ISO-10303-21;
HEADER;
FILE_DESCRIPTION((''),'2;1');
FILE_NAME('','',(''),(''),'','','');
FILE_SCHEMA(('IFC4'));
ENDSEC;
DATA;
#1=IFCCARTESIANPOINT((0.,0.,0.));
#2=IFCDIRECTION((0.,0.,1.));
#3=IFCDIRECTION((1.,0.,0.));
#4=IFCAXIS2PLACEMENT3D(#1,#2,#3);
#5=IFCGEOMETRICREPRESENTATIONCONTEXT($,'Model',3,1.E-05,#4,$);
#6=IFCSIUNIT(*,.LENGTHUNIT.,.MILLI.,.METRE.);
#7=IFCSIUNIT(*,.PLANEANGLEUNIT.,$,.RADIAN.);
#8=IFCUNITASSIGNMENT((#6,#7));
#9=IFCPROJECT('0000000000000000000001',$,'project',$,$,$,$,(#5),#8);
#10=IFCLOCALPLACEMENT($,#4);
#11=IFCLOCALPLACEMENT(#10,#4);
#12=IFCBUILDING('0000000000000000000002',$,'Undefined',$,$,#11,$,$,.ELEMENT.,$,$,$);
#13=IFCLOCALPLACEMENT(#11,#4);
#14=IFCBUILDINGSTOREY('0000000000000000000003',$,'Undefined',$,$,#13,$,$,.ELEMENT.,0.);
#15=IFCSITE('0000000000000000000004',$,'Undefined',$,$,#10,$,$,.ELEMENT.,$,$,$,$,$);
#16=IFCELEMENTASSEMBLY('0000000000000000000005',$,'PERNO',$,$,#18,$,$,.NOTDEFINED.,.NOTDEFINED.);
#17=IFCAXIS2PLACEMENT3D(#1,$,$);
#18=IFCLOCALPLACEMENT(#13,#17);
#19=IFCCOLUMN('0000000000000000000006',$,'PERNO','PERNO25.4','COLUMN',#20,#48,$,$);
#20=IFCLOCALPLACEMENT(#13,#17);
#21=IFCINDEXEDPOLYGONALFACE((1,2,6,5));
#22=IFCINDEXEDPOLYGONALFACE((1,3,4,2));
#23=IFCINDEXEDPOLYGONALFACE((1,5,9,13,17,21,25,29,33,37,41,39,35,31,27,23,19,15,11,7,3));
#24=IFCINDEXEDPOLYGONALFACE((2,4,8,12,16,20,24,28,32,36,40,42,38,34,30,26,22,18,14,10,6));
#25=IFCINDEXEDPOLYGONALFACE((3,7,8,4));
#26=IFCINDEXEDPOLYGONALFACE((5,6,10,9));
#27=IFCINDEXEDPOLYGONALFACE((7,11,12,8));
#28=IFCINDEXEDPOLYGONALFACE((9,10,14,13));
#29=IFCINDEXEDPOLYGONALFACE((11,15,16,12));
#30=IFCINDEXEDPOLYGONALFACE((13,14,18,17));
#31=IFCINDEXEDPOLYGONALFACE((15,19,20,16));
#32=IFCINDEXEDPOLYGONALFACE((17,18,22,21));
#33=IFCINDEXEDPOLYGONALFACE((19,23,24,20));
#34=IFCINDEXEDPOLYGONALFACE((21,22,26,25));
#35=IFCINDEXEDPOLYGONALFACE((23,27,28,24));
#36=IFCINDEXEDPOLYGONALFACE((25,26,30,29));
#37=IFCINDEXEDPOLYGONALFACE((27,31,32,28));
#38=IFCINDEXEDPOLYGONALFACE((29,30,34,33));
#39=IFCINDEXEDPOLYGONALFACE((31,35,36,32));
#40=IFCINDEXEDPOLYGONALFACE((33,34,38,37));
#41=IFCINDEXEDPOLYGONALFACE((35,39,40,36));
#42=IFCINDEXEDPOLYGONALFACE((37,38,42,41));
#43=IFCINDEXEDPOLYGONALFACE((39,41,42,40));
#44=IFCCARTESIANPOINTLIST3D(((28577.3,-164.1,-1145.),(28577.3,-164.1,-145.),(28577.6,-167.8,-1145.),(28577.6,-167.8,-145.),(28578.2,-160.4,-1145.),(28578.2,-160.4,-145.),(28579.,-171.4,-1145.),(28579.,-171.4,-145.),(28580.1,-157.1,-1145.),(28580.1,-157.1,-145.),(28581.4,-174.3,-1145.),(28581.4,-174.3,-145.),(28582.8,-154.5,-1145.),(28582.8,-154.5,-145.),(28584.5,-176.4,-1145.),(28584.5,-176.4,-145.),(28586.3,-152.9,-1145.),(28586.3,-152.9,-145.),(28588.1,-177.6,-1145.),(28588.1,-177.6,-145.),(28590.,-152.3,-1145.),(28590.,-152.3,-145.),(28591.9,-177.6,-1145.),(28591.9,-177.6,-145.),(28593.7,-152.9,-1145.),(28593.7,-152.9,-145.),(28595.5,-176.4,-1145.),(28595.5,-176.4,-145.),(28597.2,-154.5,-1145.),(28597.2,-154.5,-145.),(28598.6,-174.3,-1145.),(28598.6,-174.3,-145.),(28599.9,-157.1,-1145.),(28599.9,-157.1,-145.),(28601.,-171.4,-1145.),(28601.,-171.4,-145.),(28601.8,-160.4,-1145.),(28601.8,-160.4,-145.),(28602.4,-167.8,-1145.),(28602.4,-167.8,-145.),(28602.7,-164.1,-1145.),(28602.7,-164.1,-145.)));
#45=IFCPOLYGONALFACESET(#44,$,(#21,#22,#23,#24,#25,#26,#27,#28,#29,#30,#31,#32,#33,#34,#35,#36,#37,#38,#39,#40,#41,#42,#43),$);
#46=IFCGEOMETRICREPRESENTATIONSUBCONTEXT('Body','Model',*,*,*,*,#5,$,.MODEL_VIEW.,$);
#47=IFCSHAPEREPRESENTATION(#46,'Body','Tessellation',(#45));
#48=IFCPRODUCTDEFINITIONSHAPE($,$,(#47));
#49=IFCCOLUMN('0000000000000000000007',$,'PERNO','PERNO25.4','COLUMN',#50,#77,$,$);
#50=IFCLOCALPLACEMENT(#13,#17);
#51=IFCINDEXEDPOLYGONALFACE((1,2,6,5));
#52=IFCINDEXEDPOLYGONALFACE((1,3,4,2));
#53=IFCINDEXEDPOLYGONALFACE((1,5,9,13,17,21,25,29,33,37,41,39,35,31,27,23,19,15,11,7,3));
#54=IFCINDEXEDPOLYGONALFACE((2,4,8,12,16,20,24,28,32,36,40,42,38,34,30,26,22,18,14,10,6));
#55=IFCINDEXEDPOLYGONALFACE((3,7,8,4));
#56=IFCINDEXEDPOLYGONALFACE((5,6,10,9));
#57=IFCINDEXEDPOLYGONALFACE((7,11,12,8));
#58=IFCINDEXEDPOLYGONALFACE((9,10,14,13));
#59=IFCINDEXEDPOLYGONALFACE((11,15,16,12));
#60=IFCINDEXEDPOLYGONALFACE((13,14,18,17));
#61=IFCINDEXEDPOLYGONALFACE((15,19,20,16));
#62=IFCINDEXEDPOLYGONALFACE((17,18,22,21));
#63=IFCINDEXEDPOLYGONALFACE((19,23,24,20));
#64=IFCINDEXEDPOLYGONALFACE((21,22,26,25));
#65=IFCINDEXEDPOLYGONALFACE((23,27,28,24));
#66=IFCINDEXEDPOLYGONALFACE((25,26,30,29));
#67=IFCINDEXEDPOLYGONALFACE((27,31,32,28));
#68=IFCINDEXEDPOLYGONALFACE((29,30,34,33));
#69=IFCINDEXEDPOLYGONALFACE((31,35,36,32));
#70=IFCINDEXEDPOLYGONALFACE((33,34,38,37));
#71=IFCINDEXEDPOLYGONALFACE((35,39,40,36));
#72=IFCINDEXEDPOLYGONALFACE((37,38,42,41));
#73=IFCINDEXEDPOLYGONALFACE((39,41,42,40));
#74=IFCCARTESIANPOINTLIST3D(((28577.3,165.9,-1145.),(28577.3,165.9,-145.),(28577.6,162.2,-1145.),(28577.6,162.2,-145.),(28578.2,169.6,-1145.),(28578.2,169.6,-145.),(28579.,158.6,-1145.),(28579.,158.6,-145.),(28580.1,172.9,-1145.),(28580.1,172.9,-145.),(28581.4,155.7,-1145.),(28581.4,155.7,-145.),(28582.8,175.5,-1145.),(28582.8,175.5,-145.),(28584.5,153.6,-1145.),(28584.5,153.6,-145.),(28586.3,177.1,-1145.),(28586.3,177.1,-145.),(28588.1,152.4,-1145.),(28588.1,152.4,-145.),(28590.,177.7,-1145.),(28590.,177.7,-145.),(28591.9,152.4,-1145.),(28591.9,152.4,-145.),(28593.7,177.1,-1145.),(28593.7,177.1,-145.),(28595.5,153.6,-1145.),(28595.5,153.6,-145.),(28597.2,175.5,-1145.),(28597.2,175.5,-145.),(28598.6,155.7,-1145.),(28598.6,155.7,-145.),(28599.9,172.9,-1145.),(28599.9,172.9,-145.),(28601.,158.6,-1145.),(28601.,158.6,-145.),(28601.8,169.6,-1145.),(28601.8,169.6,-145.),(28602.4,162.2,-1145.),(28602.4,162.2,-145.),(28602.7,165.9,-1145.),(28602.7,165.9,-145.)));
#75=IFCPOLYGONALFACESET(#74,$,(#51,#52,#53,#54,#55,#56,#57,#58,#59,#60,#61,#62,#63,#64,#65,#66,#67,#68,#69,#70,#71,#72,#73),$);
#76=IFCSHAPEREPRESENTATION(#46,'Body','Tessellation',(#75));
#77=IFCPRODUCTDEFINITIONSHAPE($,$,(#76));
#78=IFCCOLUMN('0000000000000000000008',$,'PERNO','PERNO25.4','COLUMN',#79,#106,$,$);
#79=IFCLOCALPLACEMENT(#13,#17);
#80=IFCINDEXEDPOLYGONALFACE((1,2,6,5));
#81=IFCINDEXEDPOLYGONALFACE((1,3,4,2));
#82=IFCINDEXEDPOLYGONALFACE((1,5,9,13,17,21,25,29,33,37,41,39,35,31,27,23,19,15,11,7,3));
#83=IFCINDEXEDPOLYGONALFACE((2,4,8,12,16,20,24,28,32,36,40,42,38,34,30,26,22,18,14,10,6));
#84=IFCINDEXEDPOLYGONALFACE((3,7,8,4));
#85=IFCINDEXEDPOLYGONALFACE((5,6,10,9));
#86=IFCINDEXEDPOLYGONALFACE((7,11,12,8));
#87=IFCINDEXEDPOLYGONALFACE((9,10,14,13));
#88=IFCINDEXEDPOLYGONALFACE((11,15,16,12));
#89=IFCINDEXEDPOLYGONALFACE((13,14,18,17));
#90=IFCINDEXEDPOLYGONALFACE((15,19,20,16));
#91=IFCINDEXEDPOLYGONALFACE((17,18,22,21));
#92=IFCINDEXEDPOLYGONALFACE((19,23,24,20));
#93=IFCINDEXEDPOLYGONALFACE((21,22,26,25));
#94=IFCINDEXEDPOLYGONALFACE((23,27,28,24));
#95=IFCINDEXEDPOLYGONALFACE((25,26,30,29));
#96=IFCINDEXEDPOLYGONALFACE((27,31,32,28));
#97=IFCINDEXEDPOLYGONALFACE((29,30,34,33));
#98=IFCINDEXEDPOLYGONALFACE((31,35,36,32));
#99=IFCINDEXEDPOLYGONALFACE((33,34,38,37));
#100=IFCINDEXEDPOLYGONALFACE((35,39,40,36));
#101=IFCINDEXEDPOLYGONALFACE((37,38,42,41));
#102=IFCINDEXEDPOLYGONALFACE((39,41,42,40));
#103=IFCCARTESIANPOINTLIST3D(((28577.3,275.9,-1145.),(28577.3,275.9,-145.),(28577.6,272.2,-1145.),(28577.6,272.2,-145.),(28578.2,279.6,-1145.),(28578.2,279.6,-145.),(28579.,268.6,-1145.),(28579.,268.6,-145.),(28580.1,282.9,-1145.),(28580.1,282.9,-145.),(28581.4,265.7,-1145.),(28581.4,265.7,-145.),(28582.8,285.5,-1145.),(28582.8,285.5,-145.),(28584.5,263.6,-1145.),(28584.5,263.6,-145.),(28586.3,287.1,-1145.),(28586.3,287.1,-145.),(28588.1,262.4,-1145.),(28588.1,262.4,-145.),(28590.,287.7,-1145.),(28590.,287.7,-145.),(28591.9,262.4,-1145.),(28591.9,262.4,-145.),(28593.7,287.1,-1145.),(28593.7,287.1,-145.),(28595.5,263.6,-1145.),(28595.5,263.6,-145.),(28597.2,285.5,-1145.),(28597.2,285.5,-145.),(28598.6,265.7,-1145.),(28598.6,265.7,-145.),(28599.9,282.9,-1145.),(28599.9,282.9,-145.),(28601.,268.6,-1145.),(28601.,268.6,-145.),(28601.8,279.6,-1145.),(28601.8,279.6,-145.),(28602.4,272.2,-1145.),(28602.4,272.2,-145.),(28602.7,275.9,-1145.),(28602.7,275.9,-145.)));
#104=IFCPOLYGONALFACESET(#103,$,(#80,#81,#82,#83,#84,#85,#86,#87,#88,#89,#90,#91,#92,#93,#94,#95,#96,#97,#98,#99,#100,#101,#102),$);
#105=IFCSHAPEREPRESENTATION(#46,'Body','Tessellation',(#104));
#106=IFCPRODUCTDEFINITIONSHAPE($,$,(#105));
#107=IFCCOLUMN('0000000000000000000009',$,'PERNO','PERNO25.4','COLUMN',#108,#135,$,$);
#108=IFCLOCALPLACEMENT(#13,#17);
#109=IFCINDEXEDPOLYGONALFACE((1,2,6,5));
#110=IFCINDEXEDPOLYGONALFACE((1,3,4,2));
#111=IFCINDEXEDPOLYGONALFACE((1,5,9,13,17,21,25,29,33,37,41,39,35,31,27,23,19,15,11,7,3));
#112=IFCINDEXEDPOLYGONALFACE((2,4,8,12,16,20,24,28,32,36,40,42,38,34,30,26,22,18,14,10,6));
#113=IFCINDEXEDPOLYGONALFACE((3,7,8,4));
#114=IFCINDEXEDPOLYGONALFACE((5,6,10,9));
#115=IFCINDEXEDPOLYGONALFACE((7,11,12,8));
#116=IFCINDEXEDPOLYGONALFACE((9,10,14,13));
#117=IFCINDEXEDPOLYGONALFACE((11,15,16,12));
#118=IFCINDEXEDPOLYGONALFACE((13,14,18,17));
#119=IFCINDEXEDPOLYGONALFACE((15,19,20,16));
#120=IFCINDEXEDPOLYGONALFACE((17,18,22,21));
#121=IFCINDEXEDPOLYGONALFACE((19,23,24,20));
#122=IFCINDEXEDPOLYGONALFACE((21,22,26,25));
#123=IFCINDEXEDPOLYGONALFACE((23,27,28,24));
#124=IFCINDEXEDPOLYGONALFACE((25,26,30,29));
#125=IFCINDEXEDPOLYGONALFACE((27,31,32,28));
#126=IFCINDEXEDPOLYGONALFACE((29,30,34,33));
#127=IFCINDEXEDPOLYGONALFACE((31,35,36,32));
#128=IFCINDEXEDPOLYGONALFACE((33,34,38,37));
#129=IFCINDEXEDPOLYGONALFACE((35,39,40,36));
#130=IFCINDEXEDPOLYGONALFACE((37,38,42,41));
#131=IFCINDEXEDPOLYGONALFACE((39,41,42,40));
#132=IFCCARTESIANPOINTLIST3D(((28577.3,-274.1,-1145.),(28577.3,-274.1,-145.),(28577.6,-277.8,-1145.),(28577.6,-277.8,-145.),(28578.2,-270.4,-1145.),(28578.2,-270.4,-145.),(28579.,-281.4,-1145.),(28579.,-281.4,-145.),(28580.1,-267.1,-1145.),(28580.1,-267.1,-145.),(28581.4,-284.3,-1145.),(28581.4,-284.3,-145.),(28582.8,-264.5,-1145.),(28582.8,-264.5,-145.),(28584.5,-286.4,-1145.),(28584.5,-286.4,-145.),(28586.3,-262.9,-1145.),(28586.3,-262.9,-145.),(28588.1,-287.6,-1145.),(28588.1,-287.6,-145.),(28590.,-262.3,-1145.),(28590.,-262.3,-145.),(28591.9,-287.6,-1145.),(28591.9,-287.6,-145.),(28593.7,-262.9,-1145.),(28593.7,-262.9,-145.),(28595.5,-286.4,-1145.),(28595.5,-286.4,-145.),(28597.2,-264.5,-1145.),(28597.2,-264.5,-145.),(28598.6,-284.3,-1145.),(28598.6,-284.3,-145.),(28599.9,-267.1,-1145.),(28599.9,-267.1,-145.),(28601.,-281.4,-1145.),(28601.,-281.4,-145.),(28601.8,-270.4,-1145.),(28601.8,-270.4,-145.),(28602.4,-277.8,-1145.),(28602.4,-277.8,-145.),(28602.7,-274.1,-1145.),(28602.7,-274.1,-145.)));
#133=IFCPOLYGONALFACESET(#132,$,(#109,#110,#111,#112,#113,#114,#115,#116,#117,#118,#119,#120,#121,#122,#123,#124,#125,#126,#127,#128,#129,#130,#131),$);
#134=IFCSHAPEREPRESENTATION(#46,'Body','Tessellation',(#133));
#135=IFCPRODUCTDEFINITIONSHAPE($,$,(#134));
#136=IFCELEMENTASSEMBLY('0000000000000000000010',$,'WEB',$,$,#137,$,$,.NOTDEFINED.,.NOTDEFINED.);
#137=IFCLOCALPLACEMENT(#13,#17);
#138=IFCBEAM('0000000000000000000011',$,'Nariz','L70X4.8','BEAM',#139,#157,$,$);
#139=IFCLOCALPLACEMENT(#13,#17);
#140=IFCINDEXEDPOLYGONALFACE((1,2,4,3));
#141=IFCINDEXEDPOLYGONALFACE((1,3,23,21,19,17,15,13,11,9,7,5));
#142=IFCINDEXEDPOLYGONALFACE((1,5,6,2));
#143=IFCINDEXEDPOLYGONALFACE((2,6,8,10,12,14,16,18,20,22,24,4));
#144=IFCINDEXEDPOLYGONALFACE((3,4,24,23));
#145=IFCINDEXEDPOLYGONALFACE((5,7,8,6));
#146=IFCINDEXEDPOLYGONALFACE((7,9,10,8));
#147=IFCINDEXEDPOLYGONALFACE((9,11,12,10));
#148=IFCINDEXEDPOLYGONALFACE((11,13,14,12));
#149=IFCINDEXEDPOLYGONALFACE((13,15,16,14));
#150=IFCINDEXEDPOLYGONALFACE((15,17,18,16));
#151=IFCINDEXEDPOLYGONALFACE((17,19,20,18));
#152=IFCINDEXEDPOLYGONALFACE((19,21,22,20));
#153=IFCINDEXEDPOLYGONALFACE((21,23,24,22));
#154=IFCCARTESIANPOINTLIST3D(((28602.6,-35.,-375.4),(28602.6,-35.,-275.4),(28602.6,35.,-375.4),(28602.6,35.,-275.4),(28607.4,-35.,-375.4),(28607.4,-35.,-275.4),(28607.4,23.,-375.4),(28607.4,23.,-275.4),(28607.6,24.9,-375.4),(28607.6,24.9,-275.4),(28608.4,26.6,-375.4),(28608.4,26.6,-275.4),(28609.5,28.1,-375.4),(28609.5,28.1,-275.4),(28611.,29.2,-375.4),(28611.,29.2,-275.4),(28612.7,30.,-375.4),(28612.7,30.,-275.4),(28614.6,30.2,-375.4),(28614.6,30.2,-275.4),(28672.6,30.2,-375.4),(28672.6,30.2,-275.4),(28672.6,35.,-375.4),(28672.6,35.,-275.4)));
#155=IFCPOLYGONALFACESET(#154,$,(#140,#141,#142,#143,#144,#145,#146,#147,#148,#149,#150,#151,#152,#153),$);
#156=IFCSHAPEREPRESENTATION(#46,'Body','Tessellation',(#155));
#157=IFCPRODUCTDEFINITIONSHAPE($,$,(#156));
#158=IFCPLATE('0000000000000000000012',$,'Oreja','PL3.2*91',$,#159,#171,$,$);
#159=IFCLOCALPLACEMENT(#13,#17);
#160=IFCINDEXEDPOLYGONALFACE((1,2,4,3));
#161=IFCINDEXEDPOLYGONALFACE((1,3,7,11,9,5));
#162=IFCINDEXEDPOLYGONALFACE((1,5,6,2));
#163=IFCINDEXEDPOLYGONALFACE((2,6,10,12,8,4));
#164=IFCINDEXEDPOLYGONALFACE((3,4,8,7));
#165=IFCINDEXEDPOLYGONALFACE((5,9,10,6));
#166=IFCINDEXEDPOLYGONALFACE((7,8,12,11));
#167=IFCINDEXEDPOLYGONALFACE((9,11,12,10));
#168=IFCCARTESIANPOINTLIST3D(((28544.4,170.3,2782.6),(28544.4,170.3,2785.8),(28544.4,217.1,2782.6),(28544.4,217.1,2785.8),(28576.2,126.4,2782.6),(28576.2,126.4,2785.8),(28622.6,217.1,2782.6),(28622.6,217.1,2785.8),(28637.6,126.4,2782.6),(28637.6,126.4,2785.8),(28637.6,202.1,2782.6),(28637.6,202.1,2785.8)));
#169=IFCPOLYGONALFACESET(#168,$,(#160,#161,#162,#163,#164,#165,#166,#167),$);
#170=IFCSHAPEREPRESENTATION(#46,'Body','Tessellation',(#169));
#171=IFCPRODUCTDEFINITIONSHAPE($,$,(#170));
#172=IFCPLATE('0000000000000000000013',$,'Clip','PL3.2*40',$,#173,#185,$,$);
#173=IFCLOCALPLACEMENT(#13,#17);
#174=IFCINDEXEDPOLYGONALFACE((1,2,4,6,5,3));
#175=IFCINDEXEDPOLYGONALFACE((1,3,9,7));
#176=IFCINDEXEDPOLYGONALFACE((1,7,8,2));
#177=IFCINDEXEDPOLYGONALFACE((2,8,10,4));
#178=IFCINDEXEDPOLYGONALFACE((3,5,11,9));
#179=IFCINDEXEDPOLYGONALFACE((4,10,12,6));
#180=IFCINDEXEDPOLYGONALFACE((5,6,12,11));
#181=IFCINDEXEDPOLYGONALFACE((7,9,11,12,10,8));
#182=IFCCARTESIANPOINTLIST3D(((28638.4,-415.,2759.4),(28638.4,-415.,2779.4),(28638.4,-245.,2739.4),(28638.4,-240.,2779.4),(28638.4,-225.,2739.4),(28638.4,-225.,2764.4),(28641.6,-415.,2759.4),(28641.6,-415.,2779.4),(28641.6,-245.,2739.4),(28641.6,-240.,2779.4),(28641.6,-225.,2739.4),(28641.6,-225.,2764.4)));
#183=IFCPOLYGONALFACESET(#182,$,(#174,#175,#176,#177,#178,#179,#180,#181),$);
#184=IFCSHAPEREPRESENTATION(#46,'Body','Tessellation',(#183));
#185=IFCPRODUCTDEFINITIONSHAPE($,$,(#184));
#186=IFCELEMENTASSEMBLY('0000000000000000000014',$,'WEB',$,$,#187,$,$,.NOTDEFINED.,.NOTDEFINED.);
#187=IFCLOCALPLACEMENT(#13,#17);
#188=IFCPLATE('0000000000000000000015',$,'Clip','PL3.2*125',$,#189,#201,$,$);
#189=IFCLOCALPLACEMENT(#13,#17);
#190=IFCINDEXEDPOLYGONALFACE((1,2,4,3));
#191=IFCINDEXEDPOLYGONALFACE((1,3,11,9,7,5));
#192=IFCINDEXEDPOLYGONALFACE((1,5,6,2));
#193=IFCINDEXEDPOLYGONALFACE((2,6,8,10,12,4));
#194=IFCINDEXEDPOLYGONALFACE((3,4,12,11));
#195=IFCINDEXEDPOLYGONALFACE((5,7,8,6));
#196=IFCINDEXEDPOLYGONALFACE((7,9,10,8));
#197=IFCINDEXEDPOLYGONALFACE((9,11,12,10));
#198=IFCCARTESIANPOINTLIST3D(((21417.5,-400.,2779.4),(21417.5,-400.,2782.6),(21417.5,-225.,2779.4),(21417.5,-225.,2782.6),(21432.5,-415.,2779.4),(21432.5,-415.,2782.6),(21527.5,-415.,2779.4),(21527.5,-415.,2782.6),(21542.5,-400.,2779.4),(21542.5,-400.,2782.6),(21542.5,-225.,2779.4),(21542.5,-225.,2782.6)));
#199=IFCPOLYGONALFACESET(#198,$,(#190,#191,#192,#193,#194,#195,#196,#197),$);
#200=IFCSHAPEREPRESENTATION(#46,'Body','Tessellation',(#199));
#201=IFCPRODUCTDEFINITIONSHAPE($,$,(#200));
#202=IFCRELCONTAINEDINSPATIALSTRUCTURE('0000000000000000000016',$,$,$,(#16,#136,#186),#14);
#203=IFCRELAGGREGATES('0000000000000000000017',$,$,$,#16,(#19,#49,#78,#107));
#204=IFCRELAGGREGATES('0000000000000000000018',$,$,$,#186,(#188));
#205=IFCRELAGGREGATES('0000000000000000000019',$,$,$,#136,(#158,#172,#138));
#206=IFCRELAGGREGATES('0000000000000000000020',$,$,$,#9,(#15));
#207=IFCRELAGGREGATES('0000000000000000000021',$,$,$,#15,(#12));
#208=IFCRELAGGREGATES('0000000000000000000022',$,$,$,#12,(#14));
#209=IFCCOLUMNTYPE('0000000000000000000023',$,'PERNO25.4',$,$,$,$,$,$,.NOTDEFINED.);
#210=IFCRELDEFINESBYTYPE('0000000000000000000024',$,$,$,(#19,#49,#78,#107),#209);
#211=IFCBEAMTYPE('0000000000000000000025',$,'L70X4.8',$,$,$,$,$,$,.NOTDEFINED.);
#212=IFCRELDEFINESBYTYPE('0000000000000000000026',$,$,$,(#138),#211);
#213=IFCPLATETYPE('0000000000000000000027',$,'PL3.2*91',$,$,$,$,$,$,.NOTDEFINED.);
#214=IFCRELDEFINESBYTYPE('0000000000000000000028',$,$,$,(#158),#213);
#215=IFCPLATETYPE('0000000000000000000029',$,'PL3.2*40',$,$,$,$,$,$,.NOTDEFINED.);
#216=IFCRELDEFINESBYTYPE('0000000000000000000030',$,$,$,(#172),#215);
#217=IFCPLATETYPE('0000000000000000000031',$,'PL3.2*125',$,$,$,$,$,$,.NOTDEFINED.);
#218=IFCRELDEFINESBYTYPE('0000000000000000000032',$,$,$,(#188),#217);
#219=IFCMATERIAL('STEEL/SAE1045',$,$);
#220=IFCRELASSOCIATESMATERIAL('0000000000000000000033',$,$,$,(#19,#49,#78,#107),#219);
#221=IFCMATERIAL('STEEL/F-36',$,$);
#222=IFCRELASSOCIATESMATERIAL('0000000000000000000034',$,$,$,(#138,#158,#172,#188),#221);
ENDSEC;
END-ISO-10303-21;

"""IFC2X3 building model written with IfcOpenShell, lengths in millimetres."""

from ifc_helpers import new_model, si_unit, frame, origin_with_axes, origin_2d_with_axis, place, context, subcontext, project, spatial, polyline, circle, l_section, outline, extrude, material, type_object, element, aggregate, save


model = new_model("IFC2X3")

# Units and contexts
model_context = context("Model", 3, precision=1e-05, world=origin_with_axes())
body_context = subcontext(model_context, "Body", "Model", "MODEL_VIEW")
ifc_project = project(units=[si_unit("LENGTHUNIT", "METRE", prefix="MILLI"), si_unit("PLANEANGLEUNIT", "RADIAN")], contexts=[model_context])

# Site, building, storey
site_placement = place(None, origin_with_axes())
site = spatial("IfcSite", under=ifc_project, at=site_placement, Name="Undefined", CompositionType="ELEMENT")
building_placement = place(site_placement, origin_with_axes())
building = spatial("IfcBuilding", under=site, at=building_placement, Name="Undefined", CompositionType="ELEMENT")
storey_placement = place(building_placement, origin_with_axes())
storey = spatial("IfcBuildingStorey", under=building, at=storey_placement, Name="Undefined", CompositionType="ELEMENT", Elevation=0.0)

# Element assembly, columns
assembly_1_placement = place(storey_placement, origin_with_axes())
assembly_1 = element("IfcElementAssembly", 1, at=assembly_1_placement, inside=storey, Name="PERNO", AssemblyPlace="NOTDEFINED", PredefinedType="NOTDEFINED")
ifc_material_1 = material(Name="STEEL/SAE1045")
column_type = type_object("IfcColumnType", Name="PERNO25.4", PredefinedType="NOTDEFINED")
column_1_placement = place(assembly_1_placement, frame((28590.0, -165.0, -1145.0), z_axis=(0.0, 0.0, 1.0), x_axis=(1.0, 0.0, 0.0)))
column_1 = element("IfcColumn", 2, at=column_1_placement, type_object=column_type, material=ifc_material_1, Name="PERNO", Description="PERNO25.4", ObjectType="COLUMN", context=body_context, shape_type="SweptSolid", body=[
    extrude(circle(Radius=12.7, at=origin_2d_with_axis()), frame((0.0, 0.0, 1000.0), z_axis=(0.0, 0.0, -1.0), x_axis=(0.0, 1.0, 0.0)), (0.0, 0.0, 1.0), 1000.0),
])
column_2_placement = place(assembly_1_placement, frame((28590.0, 165.0, -1145.0), z_axis=(0.0, 0.0, 1.0), x_axis=(1.0, 0.0, 0.0)))
column_2 = element("IfcColumn", 3, at=column_2_placement, type_object=column_type, material=ifc_material_1, Name="PERNO", Description="PERNO25.4", ObjectType="COLUMN", context=body_context, shape_type="SweptSolid", body=[
    extrude(circle(Radius=12.7, at=origin_2d_with_axis()), frame((0.0, 0.0, 1000.0), z_axis=(0.0, 0.0, -1.0), x_axis=(0.0, 1.0, 0.0)), (0.0, 0.0, 1.0), 1000.0),
])
column_3_placement = place(assembly_1_placement, frame((28590.0, 275.0, -1145.0), z_axis=(0.0, 0.0, 1.0), x_axis=(1.0, 0.0, 0.0)))
column_3 = element("IfcColumn", 4, at=column_3_placement, type_object=column_type, material=ifc_material_1, Name="PERNO", Description="PERNO25.4", ObjectType="COLUMN", context=body_context, shape_type="SweptSolid", body=[
    extrude(circle(Radius=12.7, at=origin_2d_with_axis()), frame((0.0, 0.0, 1000.0), z_axis=(0.0, 0.0, -1.0), x_axis=(0.0, 1.0, 0.0)), (0.0, 0.0, 1.0), 1000.0),
])
column_4_placement = place(assembly_1_placement, frame((28590.0, -275.0, -1145.0), z_axis=(0.0, 0.0, 1.0), x_axis=(1.0, 0.0, 0.0)))
column_4 = element("IfcColumn", 5, at=column_4_placement, type_object=column_type, material=ifc_material_1, Name="PERNO", Description="PERNO25.4", ObjectType="COLUMN", context=body_context, shape_type="SweptSolid", body=[
    extrude(circle(Radius=12.7, at=origin_2d_with_axis()), frame((0.0, 0.0, 1000.0), z_axis=(0.0, 0.0, -1.0), x_axis=(0.0, 1.0, 0.0)), (0.0, 0.0, 1.0), 1000.0),
])
aggregate(assembly_1, [column_1, column_2, column_3, column_4])

# Element assembly, beam, plates
assembly_2_placement = place(storey_placement, origin_with_axes())
assembly_2 = element("IfcElementAssembly", 6, at=assembly_2_placement, inside=storey, Name="WEB", AssemblyPlace="NOTDEFINED", PredefinedType="NOTDEFINED")
ifc_material_2 = material(Name="STEEL/F-36")
beam_type = type_object("IfcBeamType", Name="L70X4.8", PredefinedType="NOTDEFINED")
beam_placement = place(assembly_2_placement, frame((28637.6, 0.0, -375.4), z_axis=(0.0, -1.0, 0.0), x_axis=(0.0, 0.0, 1.0)))
beam = element("IfcBeam", 7, at=beam_placement, type_object=beam_type, material=ifc_material_2, Name="Nariz", Description="L70X4.8", ObjectType="BEAM", context=body_context, shape_type="SweptSolid", body=[
    extrude(l_section(Depth=70.0, Width=70.0, Thickness=4.8, FilletRadius=7.2, at=origin_2d_with_axis()), frame((100.0, 0.0, 0.0), z_axis=(-1.0, 0.0, 0.0), x_axis=(0.0, -1.0, 0.0)), (0.0, 0.0, 1.0), 100.0),
])
plate_type_1 = type_object("IfcPlateType", Name="PL3.2*91", PredefinedType="NOTDEFINED")
plate_1_placement = place(assembly_2_placement, frame((28637.6, 217.1, 2784.2), z_axis=(0.0, -0.000039, 1.0), x_axis=(-1.0, -0.000012, 0.0)))
plate_1 = element("IfcPlate", 8, at=plate_1_placement, type_object=plate_type_1, material=ifc_material_2, Name="Oreja", Description="PL3.2*91", context=body_context, shape_type="SweptSolid", body=[
    extrude(outline(polyline([(0.0, 15.0), (15.0, 0.0), (93.2, 0.0), (93.2, 46.7), (61.4, 90.7), (0.0, 90.7), (0.0, 15.0)])), frame((0.0, 0.0, -1.6), z_axis=(0.0, 0.0, 1.0), x_axis=(1.0, 0.0, 0.0)), (0.0, 0.0, 1.0), 3.2),
])
plate_type_2 = type_object("IfcPlateType", Name="PL3.2*40", PredefinedType="NOTDEFINED")
plate_2_placement = place(assembly_2_placement, frame((28640.0, -225.0, 2739.4), z_axis=(1.0, 0.0, 0.0), x_axis=(0.0, -0.000007, 1.0)))
plate_2 = element("IfcPlate", 9, at=plate_2_placement, type_object=plate_type_2, material=ifc_material_2, Name="Clip", Description="PL3.2*40", context=body_context, shape_type="SweptSolid", body=[
    extrude(outline(polyline([(0.0, 0.0), (25.0, 0.0), (40.0, 15.0), (40.0, 190.0), (20.0, 190.0), (0.0, 20.0), (0.0, 0.0)])), frame((0.0, 0.0, -1.6), z_axis=(0.0, 0.0, 1.0), x_axis=(1.0, 0.0, 0.0)), (0.0, 0.0, 1.0), 3.2),
])

# Element assembly, plate
assembly_3_placement = place(storey_placement, origin_with_axes())
assembly_3 = element("IfcElementAssembly", 10, at=assembly_3_placement, inside=storey, Name="WEB", AssemblyPlace="NOTDEFINED", PredefinedType="NOTDEFINED")
plate_type_3 = type_object("IfcPlateType", Name="PL3.2*125", PredefinedType="NOTDEFINED")
plate_3_placement = place(assembly_3_placement, frame((21542.5, -225.0, 2781.0), z_axis=(0.0, -0.000007, 1.0), x_axis=(-1.0, 0.0, 0.0)))
plate_3 = element("IfcPlate", 11, at=plate_3_placement, type_object=plate_type_3, material=ifc_material_2, Name="Clip", Description="PL3.2*125", context=body_context, shape_type="SweptSolid", body=[
    extrude(outline(polyline([(0.0, 0.0), (125.0, 0.0), (125.0, 175.0), (110.0, 190.0), (15.0, 190.0), (0.0, 175.0), (0.0, 0.0)])), frame((0.0, 0.0, -1.6), z_axis=(0.0, 0.0, 1.0), x_axis=(1.0, 0.0, 0.0)), (0.0, 0.0, 1.0), 3.2),
])

aggregate(assembly_3, [plate_3])

aggregate(assembly_2, [plate_1, plate_2, beam])

save(model, "model.ifc")
